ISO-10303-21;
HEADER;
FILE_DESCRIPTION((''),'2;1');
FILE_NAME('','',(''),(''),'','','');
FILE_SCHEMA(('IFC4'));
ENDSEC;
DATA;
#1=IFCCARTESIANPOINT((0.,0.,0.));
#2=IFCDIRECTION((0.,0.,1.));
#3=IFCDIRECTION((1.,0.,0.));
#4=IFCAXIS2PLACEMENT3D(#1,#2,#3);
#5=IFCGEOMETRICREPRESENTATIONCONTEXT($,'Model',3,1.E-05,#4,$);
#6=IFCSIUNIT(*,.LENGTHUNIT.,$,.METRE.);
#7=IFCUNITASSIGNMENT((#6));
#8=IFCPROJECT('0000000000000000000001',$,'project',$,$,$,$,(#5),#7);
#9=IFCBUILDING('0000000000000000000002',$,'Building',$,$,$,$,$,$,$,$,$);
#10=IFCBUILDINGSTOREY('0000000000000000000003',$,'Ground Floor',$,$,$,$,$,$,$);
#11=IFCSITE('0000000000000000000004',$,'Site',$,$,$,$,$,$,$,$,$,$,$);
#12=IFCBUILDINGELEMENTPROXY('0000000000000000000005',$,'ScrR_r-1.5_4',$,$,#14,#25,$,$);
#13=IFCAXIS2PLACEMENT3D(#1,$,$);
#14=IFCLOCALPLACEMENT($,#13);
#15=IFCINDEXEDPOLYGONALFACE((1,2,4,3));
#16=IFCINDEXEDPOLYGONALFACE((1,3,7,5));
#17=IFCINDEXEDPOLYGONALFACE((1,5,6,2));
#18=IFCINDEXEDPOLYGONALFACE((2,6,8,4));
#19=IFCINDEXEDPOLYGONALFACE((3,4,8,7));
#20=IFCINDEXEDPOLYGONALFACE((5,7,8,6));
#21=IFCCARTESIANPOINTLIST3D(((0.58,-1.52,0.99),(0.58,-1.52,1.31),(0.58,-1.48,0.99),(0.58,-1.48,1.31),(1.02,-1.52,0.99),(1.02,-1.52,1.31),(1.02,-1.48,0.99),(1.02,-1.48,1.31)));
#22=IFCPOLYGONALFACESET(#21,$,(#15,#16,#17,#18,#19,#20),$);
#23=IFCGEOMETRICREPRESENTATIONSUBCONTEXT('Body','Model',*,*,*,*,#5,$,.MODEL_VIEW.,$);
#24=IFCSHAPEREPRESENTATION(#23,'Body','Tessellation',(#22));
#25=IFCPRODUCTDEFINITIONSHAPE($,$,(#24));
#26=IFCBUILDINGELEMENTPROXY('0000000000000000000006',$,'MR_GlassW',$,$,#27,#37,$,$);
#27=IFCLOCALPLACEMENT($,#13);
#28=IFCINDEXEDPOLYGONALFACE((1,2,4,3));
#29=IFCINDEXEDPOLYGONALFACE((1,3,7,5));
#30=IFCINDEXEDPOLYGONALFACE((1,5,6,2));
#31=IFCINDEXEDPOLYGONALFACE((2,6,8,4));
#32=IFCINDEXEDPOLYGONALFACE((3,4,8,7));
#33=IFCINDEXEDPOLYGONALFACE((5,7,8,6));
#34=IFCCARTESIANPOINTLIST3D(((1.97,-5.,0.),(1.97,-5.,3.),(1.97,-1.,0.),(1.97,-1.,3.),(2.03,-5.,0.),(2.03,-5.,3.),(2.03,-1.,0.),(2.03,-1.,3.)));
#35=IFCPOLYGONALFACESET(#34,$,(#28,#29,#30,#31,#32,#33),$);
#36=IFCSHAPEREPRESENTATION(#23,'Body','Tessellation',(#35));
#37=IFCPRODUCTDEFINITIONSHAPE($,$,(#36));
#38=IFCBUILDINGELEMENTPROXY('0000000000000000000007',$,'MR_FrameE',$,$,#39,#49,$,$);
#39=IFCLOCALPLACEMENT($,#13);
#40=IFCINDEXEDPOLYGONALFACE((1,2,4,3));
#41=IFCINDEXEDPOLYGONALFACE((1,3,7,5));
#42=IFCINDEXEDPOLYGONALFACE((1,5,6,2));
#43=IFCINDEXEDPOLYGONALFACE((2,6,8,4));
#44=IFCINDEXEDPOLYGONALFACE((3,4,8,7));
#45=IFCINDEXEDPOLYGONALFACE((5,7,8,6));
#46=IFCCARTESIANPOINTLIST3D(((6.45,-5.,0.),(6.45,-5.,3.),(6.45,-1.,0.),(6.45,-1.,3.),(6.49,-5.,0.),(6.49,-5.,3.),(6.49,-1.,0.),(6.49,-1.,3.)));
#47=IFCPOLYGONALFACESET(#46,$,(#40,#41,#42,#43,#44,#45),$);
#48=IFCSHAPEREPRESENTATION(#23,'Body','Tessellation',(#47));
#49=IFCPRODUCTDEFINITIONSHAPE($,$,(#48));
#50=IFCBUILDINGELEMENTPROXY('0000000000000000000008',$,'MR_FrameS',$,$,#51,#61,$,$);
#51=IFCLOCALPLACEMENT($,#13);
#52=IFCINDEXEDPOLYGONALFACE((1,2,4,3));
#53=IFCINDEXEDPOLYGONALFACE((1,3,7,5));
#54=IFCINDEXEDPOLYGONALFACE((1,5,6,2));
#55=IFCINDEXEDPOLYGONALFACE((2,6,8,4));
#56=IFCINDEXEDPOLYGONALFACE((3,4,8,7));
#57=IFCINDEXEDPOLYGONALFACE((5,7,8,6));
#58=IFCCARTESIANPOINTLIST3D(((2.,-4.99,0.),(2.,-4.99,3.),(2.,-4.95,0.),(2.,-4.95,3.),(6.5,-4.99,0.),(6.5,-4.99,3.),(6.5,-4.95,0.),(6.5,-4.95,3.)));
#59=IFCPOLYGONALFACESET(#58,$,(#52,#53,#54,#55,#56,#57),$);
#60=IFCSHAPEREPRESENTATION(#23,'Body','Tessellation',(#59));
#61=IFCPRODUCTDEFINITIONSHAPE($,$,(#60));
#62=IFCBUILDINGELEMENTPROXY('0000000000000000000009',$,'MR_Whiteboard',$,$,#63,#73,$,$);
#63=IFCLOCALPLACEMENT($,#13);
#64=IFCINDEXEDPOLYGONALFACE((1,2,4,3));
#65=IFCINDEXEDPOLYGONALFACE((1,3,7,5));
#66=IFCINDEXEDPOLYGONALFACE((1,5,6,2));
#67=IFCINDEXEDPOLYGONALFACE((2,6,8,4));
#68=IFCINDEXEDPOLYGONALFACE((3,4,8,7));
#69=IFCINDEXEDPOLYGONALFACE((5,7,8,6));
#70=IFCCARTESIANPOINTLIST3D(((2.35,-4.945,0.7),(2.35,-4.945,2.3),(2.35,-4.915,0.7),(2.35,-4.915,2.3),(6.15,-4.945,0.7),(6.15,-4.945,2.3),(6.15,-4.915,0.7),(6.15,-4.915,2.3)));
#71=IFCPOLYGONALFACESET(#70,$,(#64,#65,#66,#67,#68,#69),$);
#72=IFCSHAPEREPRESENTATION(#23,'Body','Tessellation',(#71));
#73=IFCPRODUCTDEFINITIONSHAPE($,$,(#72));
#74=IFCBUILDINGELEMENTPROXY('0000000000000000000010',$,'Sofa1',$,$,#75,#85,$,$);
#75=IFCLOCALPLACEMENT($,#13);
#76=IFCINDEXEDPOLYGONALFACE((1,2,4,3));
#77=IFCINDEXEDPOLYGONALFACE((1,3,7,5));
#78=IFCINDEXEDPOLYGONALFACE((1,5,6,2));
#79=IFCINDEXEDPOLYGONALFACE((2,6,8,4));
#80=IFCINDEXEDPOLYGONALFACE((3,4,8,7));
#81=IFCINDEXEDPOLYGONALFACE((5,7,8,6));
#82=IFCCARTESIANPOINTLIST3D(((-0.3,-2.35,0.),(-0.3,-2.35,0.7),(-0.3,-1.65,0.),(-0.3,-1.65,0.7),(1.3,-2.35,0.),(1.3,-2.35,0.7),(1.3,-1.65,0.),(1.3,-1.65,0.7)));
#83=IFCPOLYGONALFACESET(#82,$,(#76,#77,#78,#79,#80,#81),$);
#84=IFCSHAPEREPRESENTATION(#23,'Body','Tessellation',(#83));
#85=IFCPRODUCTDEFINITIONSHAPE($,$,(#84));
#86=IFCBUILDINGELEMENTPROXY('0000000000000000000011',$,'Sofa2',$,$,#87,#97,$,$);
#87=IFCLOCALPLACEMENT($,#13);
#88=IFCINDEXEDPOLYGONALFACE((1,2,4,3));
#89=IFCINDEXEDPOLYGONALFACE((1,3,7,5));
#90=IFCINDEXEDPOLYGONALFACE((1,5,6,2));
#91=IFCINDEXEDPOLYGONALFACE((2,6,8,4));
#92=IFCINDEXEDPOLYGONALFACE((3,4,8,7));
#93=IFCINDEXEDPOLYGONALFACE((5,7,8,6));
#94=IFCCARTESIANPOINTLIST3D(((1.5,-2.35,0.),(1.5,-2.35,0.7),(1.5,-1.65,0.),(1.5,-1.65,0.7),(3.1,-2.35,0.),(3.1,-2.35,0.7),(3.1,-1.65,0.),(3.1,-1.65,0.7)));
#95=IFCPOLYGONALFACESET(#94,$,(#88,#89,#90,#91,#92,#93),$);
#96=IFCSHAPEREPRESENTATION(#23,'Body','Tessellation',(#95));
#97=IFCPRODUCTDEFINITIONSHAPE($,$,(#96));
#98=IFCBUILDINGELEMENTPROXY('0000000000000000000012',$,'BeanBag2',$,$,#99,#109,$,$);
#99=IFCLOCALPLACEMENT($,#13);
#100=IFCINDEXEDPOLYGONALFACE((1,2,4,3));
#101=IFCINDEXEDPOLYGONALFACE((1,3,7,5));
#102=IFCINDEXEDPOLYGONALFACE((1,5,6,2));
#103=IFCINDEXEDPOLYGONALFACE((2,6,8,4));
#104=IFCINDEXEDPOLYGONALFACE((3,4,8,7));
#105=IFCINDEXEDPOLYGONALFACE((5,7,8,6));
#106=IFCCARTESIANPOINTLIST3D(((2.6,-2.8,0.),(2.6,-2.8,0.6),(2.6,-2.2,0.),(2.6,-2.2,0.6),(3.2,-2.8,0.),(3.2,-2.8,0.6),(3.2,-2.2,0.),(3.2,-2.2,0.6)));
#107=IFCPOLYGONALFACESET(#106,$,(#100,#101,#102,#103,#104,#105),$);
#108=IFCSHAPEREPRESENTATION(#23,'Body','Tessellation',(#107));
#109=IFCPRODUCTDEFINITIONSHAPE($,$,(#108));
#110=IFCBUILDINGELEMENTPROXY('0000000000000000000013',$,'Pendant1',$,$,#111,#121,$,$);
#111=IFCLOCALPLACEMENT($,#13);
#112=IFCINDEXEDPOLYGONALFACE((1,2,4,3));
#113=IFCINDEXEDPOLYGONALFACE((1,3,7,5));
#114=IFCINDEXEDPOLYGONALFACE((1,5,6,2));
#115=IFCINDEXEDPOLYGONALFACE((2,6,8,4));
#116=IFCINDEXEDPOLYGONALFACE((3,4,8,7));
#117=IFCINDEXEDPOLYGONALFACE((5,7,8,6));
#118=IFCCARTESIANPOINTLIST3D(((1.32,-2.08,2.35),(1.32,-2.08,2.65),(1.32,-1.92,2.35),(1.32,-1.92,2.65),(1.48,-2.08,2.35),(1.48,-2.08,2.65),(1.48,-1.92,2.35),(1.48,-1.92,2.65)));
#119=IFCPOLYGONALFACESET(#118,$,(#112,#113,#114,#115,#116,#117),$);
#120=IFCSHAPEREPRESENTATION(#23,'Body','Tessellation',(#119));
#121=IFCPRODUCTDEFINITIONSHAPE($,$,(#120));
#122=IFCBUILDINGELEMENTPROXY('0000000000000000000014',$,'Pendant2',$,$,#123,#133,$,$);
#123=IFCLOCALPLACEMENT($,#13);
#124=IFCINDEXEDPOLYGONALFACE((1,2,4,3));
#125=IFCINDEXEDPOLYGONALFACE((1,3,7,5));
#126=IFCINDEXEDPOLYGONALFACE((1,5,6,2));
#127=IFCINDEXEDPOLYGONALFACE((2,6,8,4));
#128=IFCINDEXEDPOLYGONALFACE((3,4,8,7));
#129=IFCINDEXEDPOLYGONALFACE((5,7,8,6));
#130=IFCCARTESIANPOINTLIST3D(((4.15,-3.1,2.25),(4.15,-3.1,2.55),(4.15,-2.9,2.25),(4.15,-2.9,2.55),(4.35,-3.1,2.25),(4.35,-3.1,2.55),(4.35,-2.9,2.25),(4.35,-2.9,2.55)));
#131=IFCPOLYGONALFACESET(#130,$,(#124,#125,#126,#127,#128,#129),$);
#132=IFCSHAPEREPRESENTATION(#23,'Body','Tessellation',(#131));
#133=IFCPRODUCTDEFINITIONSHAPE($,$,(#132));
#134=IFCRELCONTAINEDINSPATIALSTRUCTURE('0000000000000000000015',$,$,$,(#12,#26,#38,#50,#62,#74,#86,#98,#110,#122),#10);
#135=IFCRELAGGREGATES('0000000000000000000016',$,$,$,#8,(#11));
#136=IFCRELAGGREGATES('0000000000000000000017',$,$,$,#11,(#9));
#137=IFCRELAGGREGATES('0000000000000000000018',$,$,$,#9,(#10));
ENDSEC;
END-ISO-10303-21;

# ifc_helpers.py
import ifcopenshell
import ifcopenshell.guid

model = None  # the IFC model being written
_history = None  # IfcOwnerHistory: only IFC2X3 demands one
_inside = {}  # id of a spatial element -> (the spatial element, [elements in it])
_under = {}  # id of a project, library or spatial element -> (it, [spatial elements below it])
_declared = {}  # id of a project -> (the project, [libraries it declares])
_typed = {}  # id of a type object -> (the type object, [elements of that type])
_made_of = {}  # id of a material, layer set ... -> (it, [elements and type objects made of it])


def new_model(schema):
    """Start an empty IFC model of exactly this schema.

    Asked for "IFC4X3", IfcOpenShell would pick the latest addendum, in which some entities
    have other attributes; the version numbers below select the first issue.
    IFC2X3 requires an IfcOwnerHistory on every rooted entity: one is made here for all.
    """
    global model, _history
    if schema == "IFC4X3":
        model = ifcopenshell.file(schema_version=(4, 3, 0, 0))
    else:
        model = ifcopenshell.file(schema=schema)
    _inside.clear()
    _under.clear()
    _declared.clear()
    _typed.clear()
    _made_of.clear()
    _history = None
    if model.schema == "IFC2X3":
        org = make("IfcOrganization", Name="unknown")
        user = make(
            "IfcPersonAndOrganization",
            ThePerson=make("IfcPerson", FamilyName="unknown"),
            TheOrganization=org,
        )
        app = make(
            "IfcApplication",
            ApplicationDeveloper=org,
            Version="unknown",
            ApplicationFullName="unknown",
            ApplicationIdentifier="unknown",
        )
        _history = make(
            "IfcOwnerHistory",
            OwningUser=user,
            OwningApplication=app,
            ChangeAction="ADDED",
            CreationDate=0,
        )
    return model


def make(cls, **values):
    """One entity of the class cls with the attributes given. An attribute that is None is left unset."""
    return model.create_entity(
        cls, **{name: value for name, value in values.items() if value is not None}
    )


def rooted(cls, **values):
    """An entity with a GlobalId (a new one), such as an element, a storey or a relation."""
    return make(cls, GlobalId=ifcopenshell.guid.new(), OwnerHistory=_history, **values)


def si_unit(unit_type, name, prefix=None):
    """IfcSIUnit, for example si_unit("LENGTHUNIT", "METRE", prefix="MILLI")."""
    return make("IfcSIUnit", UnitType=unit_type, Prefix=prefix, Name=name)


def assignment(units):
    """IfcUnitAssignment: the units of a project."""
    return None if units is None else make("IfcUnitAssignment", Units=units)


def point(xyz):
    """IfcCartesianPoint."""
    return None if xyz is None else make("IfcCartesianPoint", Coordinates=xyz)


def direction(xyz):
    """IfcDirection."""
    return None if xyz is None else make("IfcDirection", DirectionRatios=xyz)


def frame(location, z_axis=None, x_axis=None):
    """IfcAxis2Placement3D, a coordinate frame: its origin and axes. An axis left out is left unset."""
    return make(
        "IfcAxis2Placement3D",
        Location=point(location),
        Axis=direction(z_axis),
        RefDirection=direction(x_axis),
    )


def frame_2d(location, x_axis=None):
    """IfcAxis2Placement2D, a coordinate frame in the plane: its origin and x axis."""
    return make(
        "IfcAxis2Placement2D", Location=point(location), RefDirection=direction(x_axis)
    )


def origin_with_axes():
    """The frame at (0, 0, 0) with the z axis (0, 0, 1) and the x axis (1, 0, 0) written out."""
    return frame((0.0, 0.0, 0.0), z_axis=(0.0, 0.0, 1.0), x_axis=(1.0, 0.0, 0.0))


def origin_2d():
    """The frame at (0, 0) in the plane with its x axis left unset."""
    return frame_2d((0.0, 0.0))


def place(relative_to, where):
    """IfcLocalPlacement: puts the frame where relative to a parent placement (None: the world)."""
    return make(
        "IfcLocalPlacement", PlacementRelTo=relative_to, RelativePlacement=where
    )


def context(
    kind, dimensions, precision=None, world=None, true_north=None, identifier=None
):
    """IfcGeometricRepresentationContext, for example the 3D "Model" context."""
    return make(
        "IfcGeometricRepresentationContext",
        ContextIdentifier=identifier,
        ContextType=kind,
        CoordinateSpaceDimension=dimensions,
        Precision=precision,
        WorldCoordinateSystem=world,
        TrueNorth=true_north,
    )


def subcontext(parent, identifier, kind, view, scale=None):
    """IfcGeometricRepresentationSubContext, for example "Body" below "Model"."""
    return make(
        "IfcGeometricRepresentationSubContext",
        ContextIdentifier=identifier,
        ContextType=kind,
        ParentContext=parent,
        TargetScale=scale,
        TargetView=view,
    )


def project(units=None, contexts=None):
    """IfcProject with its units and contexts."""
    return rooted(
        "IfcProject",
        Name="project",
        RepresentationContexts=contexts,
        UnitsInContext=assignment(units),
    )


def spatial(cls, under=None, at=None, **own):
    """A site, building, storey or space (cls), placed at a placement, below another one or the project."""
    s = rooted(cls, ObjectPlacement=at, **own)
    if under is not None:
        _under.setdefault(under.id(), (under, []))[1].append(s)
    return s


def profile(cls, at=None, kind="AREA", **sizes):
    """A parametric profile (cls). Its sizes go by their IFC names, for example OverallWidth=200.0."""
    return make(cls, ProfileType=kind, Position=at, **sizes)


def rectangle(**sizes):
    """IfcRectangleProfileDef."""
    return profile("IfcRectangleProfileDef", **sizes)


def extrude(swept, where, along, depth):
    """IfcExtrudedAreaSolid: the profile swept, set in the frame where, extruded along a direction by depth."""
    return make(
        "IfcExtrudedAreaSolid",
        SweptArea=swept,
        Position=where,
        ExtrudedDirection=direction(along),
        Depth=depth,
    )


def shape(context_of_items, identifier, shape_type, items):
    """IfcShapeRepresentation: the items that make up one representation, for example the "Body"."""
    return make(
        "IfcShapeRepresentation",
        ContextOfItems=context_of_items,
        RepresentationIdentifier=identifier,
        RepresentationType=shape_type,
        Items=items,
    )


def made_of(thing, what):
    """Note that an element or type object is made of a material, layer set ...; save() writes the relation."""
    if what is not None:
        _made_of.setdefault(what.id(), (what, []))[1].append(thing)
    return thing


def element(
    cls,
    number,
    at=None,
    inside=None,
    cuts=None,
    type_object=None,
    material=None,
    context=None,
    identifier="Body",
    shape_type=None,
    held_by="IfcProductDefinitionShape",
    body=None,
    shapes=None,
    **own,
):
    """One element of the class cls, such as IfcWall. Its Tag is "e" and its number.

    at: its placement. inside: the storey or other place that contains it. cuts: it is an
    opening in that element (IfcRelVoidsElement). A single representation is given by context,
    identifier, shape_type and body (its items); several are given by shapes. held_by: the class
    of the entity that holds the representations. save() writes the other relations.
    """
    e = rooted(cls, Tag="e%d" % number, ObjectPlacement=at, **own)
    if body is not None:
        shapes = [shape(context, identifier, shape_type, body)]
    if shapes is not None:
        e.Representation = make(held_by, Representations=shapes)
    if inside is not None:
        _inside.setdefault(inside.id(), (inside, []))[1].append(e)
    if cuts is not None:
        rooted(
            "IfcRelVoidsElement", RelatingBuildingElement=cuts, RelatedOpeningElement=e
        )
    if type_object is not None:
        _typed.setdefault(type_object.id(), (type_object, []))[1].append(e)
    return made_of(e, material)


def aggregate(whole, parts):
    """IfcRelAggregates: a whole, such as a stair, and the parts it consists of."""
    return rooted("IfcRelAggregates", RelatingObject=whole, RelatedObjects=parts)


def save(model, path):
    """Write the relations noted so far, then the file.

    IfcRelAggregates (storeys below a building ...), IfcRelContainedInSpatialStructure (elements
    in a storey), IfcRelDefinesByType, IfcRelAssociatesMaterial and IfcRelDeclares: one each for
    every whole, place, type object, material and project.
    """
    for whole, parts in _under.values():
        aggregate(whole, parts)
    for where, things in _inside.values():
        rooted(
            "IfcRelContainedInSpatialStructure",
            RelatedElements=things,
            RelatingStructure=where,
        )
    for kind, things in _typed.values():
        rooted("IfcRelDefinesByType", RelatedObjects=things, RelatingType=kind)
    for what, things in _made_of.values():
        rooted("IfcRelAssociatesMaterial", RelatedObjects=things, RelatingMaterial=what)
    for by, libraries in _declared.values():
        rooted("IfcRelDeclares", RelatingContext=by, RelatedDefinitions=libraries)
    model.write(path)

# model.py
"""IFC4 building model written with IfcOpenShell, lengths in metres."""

from ifc_helpers import new_model, si_unit, frame, origin_with_axes, origin_2d, place, context, subcontext, project, spatial, rectangle, extrude, element, save


model = new_model("IFC4")

# Units and contexts
model_context = context("Model", 3, precision=1e-05, world=origin_with_axes())
body_context = subcontext(model_context, "Body", "Model", "MODEL_VIEW")
ifc_project = project(units=[si_unit("LENGTHUNIT", "METRE")], contexts=[model_context])

# Site, building, storey
site = spatial("IfcSite", under=ifc_project, Name="Site")
building = spatial("IfcBuilding", under=site, Name="Building")
storey = spatial("IfcBuildingStorey", under=building, Name="Ground Floor")

# Building element proxies
for number, where, z_axis, x_axis, name in (
    (1, (0.8, -1.5, 1.15), (0.0, 0.0, 1.0), (1.0, 0.0, 0.0), "ScrR_r-1.5_4"),
):
    element("IfcBuildingElementProxy", number, at=place(None, frame(where, z_axis=z_axis, x_axis=x_axis)), inside=storey, Name=name, context=body_context, shape_type="SweptSolid", body=[
        extrude(rectangle(XDim=0.44, YDim=0.04, at=origin_2d()), frame((0.0, 0.0, -0.16)), (0.0, 0.0, 1.0), 0.32),
    ])
proxy_1_placement = place(None, frame((2.0, -3.0, 1.5), z_axis=(0.0, 0.0, 1.0), x_axis=(1.0, 0.0, 0.0)))
element("IfcBuildingElementProxy", 2, at=proxy_1_placement, inside=storey, Name="MR_GlassW", context=body_context, shape_type="SweptSolid", body=[
    extrude(rectangle(XDim=0.06, YDim=4.0, at=origin_2d()), frame((0.0, 0.0, -1.5)), (0.0, 0.0, 1.0), 3.0),
])
proxy_2_placement = place(None, frame((6.47, -3.0, 1.5), z_axis=(0.0, 0.0, 1.0), x_axis=(1.0, 0.0, 0.0)))
element("IfcBuildingElementProxy", 3, at=proxy_2_placement, inside=storey, Name="MR_FrameE", context=body_context, shape_type="SweptSolid", body=[
    extrude(rectangle(XDim=0.04, YDim=4.0, at=origin_2d()), frame((0.0, 0.0, -1.5)), (0.0, 0.0, 1.0), 3.0),
])
proxy_3_placement = place(None, frame((4.25, -4.97, 1.5), z_axis=(0.0, 0.0, 1.0), x_axis=(1.0, 0.0, 0.0)))
element("IfcBuildingElementProxy", 4, at=proxy_3_placement, inside=storey, Name="MR_FrameS", context=body_context, shape_type="SweptSolid", body=[
    extrude(rectangle(XDim=4.5, YDim=0.04, at=origin_2d()), frame((0.0, 0.0, -1.5)), (0.0, 0.0, 1.0), 3.0),
])
proxy_4_placement = place(None, frame((4.25, -4.93, 1.5), z_axis=(0.0, 0.0, 1.0), x_axis=(1.0, 0.0, 0.0)))
element("IfcBuildingElementProxy", 5, at=proxy_4_placement, inside=storey, Name="MR_Whiteboard", context=body_context, shape_type="SweptSolid", body=[
    extrude(rectangle(XDim=3.8, YDim=0.03, at=origin_2d()), frame((0.0, 0.0, -0.8)), (0.0, 0.0, 1.0), 1.6),
])
for number, where, z_axis, x_axis, name in (
    (6, (0.5, -2.0, 0.35), (0.0, 0.0, 1.0), (1.0, 0.0, 0.0), "Sofa1"),
    (7, (2.3, -2.0, 0.35), (0.0, 0.0, 1.0), (1.0, 0.0, 0.0), "Sofa2"),
):
    element("IfcBuildingElementProxy", number, at=place(None, frame(where, z_axis=z_axis, x_axis=x_axis)), inside=storey, Name=name, context=body_context, shape_type="SweptSolid", body=[
        extrude(rectangle(XDim=1.6, YDim=0.7, at=origin_2d()), frame((0.0, 0.0, -0.35)), (0.0, 0.0, 1.0), 0.7),
    ])
proxy_5_placement = place(None, frame((2.9, -2.5, 0.3), z_axis=(0.0, 0.0, 1.0), x_axis=(1.0, 0.0, 0.0)))
element("IfcBuildingElementProxy", 8, at=proxy_5_placement, inside=storey, Name="BeanBag2", context=body_context, shape_type="SweptSolid", body=[
    extrude(rectangle(XDim=0.6, YDim=0.6, at=origin_2d()), frame((0.0, 0.0, -0.3)), (0.0, 0.0, 1.0), 0.6),
])
proxy_6_placement = place(None, frame((1.4, -2.0, 2.5), z_axis=(0.0, 0.0, 1.0), x_axis=(1.0, 0.0, 0.0)))
element("IfcBuildingElementProxy", 9, at=proxy_6_placement, inside=storey, Name="Pendant1", context=body_context, shape_type="SweptSolid", body=[
    extrude(rectangle(XDim=0.16, YDim=0.16, at=origin_2d()), frame((0.0, 0.0, -0.15)), (0.0, 0.0, 1.0), 0.3),
])
proxy_7_placement = place(None, frame((4.25, -3.0, 2.4), z_axis=(0.0, 0.0, 1.0), x_axis=(1.0, 0.0, 0.0)))
element("IfcBuildingElementProxy", 10, at=proxy_7_placement, inside=storey, Name="Pendant2", context=body_context, shape_type="SweptSolid", body=[
    extrude(rectangle(XDim=0.2, YDim=0.2, at=origin_2d()), frame((0.0, 0.0, -0.15)), (0.0, 0.0, 1.0), 0.3),
])

save(model, "model.ifc")
